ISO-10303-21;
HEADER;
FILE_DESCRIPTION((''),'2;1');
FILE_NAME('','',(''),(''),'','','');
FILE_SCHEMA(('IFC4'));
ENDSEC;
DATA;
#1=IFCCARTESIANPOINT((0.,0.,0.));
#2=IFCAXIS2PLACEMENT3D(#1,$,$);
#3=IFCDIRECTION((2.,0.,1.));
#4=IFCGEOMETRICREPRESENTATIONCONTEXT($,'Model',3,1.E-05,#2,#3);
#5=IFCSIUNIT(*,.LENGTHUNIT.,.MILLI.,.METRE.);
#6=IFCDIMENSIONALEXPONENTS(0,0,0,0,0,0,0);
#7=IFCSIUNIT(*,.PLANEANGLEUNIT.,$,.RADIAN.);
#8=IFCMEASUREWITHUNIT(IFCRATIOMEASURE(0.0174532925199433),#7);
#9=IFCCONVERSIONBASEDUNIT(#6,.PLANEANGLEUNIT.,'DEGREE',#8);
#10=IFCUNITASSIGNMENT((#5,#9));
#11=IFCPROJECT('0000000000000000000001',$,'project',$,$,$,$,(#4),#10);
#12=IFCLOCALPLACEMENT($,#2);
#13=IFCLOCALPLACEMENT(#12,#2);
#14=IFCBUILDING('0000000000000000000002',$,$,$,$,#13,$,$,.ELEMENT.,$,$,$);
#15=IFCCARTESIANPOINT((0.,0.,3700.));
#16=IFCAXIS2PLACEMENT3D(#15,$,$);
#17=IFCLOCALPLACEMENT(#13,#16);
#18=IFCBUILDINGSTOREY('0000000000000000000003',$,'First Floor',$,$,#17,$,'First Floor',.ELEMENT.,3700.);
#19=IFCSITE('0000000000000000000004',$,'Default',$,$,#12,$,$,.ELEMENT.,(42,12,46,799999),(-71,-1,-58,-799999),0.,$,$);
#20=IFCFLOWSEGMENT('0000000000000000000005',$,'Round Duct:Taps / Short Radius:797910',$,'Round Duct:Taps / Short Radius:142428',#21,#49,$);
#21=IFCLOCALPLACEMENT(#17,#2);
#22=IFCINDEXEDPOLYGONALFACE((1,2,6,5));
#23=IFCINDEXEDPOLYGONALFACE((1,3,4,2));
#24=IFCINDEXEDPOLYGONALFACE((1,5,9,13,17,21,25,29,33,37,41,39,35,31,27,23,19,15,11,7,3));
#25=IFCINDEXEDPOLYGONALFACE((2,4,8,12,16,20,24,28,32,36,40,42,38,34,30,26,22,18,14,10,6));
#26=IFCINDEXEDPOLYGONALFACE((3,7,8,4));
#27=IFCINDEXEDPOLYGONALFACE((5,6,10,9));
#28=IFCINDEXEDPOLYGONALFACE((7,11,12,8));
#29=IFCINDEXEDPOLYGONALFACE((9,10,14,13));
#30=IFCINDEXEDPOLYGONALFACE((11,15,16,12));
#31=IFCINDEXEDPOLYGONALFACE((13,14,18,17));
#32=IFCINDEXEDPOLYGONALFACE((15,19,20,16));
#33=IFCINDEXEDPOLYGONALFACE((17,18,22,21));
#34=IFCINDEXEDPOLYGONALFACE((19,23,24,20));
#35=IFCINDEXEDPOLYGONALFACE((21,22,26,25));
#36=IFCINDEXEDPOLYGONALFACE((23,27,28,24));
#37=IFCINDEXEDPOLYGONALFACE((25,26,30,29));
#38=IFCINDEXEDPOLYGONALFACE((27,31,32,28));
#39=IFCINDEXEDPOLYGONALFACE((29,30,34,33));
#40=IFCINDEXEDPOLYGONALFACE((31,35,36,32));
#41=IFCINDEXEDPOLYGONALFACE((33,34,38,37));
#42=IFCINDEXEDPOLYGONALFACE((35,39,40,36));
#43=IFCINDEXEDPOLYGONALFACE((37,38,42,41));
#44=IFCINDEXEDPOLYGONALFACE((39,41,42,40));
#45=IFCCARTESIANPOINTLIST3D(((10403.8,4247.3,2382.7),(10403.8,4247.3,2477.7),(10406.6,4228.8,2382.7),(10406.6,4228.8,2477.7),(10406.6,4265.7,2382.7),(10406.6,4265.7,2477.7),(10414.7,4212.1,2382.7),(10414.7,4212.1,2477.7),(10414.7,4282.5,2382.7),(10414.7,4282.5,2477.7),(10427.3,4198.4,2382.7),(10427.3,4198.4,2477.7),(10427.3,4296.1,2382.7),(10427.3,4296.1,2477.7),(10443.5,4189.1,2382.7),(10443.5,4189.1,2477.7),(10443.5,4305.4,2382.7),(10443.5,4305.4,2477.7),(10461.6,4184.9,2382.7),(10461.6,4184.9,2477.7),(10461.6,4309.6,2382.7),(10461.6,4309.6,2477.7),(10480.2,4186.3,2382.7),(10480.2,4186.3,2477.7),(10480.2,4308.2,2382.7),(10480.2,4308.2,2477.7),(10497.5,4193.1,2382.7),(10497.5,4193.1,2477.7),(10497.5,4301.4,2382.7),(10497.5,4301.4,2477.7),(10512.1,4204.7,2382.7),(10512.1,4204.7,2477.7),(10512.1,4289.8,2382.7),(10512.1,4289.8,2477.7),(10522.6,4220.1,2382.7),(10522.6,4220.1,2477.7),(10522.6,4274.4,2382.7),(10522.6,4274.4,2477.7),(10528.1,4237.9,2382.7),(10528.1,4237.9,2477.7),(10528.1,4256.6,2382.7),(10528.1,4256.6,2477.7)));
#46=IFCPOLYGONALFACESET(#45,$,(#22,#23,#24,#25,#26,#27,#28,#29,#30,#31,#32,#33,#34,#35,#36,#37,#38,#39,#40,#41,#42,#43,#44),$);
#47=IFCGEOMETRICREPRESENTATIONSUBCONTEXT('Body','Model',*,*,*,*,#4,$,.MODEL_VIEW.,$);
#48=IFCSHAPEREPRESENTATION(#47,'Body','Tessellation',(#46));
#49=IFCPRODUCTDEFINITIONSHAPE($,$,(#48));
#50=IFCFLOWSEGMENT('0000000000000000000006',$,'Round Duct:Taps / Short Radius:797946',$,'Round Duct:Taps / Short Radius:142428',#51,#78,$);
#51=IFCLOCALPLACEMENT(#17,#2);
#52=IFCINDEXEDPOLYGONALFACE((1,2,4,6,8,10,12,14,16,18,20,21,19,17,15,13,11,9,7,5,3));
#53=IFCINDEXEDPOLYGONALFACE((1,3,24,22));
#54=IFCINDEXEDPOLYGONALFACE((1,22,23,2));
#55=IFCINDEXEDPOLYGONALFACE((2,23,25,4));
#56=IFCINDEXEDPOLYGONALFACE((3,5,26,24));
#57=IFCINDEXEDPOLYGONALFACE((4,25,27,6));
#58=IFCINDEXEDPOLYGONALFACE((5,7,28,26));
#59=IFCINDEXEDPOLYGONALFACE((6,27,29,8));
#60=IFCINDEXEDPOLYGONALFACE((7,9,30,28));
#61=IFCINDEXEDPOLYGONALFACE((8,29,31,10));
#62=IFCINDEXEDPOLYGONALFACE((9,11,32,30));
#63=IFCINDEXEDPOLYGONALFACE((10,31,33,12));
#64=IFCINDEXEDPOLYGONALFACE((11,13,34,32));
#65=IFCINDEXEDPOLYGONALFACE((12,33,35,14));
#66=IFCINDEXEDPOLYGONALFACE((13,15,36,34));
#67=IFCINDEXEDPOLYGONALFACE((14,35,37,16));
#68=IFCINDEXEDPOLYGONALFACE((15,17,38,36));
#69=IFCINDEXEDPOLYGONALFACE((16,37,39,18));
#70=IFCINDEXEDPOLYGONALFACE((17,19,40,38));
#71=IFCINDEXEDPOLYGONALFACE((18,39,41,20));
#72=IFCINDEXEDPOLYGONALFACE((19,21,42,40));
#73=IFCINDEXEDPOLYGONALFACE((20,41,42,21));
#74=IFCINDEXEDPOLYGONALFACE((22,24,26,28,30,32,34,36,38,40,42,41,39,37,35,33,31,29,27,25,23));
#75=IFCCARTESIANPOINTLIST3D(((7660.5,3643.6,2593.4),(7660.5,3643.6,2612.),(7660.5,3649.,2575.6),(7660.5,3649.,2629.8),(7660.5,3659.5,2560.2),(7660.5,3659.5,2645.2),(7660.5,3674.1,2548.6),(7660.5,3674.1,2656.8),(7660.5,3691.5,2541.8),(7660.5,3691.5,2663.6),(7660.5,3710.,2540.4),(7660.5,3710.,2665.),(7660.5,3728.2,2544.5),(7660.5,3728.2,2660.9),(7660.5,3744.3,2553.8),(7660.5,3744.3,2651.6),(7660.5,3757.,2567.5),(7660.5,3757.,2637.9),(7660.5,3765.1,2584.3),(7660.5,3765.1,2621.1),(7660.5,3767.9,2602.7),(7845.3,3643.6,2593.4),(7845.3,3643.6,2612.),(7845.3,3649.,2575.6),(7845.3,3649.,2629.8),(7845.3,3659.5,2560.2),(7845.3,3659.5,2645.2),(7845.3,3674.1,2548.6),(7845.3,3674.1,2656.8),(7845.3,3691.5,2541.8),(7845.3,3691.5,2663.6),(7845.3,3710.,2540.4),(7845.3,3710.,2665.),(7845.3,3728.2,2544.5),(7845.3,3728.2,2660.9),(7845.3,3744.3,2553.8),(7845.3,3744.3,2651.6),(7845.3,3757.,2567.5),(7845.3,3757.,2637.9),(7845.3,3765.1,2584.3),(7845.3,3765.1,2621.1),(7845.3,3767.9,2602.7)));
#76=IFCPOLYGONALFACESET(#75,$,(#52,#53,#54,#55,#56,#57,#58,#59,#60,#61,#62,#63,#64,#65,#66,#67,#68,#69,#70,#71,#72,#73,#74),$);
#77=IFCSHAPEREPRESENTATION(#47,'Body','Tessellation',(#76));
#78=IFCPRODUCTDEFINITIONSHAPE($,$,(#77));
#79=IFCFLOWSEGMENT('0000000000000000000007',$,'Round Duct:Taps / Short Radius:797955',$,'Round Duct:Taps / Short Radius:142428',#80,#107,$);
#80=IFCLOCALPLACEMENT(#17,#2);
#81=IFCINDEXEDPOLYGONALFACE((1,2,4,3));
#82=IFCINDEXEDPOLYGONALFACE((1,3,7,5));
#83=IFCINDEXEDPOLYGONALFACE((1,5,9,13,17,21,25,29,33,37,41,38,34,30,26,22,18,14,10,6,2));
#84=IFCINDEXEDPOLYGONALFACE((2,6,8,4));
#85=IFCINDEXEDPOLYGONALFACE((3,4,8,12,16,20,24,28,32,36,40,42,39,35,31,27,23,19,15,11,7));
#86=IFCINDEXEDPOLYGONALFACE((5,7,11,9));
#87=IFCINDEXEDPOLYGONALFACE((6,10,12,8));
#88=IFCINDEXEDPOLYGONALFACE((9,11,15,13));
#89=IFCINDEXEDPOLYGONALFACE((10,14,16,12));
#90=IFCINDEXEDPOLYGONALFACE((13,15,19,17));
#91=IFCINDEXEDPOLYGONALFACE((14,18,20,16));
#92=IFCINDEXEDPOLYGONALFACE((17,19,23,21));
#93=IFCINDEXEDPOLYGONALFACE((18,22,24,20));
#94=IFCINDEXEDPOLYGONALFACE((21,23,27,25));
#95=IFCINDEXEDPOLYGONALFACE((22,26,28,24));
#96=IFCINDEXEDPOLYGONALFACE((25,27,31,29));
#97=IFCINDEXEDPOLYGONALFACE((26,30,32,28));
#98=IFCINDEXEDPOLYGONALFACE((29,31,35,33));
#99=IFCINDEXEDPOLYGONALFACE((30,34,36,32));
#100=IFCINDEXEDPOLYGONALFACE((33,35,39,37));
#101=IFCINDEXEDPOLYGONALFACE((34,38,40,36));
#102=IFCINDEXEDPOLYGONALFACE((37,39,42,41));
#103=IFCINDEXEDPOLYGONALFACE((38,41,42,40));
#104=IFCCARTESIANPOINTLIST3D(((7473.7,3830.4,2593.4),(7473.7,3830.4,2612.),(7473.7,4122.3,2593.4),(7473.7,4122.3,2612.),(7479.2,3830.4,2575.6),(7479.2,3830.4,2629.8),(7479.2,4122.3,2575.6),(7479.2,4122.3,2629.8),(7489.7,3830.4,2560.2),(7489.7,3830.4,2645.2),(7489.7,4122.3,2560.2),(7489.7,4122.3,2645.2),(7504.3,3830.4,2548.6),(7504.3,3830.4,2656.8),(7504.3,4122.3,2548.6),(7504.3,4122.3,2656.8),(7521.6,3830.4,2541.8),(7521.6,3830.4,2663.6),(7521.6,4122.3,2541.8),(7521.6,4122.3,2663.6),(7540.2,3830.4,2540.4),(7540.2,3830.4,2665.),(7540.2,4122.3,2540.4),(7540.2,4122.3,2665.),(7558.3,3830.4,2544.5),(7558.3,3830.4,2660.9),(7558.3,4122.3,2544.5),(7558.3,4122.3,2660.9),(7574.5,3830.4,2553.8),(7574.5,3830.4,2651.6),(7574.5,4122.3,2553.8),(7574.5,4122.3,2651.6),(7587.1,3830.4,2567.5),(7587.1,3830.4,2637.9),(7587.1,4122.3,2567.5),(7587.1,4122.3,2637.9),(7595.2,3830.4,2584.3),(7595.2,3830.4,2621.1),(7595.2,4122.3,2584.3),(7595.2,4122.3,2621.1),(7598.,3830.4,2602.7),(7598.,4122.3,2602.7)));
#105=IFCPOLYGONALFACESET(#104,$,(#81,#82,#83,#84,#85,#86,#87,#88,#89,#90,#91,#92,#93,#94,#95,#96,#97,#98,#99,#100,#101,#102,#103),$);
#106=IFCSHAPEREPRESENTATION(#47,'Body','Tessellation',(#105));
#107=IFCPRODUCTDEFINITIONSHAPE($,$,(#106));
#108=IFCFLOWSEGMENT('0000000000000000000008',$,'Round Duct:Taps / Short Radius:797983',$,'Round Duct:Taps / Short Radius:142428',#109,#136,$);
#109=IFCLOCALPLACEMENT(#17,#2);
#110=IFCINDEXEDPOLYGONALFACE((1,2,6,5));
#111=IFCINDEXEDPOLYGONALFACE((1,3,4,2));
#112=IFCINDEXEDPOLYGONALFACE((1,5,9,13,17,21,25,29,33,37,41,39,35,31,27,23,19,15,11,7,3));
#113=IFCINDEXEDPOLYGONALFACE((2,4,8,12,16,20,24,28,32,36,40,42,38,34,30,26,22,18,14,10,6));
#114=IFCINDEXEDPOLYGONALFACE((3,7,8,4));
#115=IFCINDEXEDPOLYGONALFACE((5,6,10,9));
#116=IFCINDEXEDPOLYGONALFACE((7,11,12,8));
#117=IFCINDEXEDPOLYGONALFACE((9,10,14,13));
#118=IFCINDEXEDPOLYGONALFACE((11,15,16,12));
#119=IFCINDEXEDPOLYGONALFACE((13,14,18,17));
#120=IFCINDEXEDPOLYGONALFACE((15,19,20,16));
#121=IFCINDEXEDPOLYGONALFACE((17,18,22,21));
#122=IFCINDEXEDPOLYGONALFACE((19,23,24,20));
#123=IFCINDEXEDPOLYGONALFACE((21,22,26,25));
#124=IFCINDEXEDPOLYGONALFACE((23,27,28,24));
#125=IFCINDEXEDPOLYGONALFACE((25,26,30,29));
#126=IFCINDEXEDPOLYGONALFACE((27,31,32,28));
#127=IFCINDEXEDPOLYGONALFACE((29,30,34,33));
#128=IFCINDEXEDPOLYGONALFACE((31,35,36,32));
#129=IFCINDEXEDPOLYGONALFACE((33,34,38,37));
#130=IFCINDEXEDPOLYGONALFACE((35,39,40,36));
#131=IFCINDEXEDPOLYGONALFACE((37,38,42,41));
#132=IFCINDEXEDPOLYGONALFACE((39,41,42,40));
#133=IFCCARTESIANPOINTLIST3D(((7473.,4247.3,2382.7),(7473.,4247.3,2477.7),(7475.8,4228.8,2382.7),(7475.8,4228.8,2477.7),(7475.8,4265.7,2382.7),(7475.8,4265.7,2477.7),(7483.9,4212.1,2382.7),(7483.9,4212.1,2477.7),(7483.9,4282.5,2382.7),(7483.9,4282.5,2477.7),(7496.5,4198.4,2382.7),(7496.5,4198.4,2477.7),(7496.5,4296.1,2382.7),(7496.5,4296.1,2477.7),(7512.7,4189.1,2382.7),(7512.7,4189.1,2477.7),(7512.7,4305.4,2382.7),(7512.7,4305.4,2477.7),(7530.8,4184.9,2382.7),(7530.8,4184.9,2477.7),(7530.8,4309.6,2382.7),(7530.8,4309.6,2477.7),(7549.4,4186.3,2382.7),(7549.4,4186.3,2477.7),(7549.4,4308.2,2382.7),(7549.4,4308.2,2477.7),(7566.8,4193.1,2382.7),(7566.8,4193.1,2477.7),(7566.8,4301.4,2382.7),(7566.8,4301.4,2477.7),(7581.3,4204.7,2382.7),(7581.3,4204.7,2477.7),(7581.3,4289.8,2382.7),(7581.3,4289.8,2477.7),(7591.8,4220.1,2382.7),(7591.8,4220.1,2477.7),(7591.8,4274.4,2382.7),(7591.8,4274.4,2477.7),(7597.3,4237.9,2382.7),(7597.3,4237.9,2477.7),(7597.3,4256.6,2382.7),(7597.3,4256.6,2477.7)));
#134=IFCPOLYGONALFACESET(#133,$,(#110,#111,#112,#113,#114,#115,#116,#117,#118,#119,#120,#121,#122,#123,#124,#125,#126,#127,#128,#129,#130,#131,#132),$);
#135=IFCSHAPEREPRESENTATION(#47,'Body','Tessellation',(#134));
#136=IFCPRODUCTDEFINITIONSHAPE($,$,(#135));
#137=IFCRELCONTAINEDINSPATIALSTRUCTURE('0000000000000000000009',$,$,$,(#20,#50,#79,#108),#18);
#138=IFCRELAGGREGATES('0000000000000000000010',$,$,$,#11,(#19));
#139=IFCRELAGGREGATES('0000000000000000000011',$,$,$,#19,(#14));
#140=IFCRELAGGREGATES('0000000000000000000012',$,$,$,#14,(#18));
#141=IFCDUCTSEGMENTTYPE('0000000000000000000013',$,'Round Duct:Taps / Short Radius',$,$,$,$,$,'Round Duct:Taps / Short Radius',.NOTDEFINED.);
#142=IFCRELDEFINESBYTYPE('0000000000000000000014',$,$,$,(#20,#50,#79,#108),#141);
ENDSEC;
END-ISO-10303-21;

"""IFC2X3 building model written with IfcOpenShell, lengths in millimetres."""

from ifc_helpers import new_model, entity, si_unit, converted_unit, direction, frame, frame_2d, origin, origin_2d_with_axis, place, context, subcontext, project, spatial, circle, extrude, type_object, element, save


model = new_model("IFC2X3")

# Units and contexts
model_context = context("Model", 3, precision=1e-05, world=origin(), true_north=direction((2.0, 0.0, 1.0)))
body_context = subcontext(model_context, "Body", "Model", "MODEL_VIEW")
ifc_project = project(units=[si_unit("LENGTHUNIT", "METRE", prefix="MILLI"), converted_unit("PLANEANGLEUNIT", "DEGREE", entity("IfcRatioMeasure", 0.0174532925199433), si_unit("PLANEANGLEUNIT", "RADIAN"), dimensions=[0, 0, 0, 0, 0, 0, 0])], contexts=[model_context])

# Site, building, storey
site_placement = place(None, origin())
site = spatial("IfcSite", under=ifc_project, at=site_placement, Name="Default", CompositionType="ELEMENT", RefLatitude=(42, 12, 46, 799999), RefLongitude=(-71, -1, -58, -799999), RefElevation=0.0)
building_placement = place(site_placement, origin())
building = spatial("IfcBuilding", under=site, at=building_placement, CompositionType="ELEMENT")
storey_placement = place(building_placement, frame((0.0, 0.0, 3700.0)))
storey = spatial("IfcBuildingStorey", under=building, at=storey_placement, Name="First Floor", LongName="First Floor", CompositionType="ELEMENT", Elevation=3700.0)

# Flow segments
duct_segment_type = type_object("IfcDuctSegmentType", Name="Round Duct:Taps / Short Radius", ElementType="Round Duct:Taps / Short Radius", PredefinedType="NOTDEFINED")
flow_segment_1_placement = place(storey_placement, origin())
element("IfcFlowSegment", 1, at=flow_segment_1_placement, inside=storey, type_object=duct_segment_type, Name="Round Duct:Taps / Short Radius:797910", ObjectType="Round Duct:Taps / Short Radius:142428", context=body_context, shape_type="SweptSolid", body=[
    extrude(circle(Radius=62.5, at=frame_2d((0.0, 0.0), x_axis=(1.0, 0.0))), frame((10466.3, 4247.3, 2382.7), z_axis=(0.0, 0.0, 1.0), x_axis=(-1.0, 0.0, 0.0)), (0.0, 0.0, 1.0), 95.0),
])
flow_segment_2_placement = place(storey_placement, origin())
element("IfcFlowSegment", 2, at=flow_segment_2_placement, inside=storey, type_object=duct_segment_type, Name="Round Duct:Taps / Short Radius:797946", ObjectType="Round Duct:Taps / Short Radius:142428", context=body_context, shape_type="SweptSolid", body=[
    extrude(circle(Radius=62.5, at=frame_2d((0.0, 0.0), x_axis=(1.0, 0.0))), frame((7660.5, 3705.4, 2602.7), z_axis=(1.0, 0.0, 0.0), x_axis=(0.0, 1.0, 0.0)), (0.0, 0.0, 1.0), 184.8),
])
flow_segment_3_placement = place(storey_placement, origin())
element("IfcFlowSegment", 3, at=flow_segment_3_placement, inside=storey, type_object=duct_segment_type, Name="Round Duct:Taps / Short Radius:797955", ObjectType="Round Duct:Taps / Short Radius:142428", context=body_context, shape_type="SweptSolid", body=[
    extrude(circle(Radius=62.5, at=origin_2d_with_axis()), frame((7535.5, 3830.4, 2602.7), z_axis=(0.0, 1.0, 0.0), x_axis=(1.0, 0.0, 0.0)), (0.0, 0.0, 1.0), 291.9),
])
flow_segment_4_placement = place(storey_placement, origin())
element("IfcFlowSegment", 4, at=flow_segment_4_placement, inside=storey, type_object=duct_segment_type, Name="Round Duct:Taps / Short Radius:797983", ObjectType="Round Duct:Taps / Short Radius:142428", context=body_context, shape_type="SweptSolid", body=[
    extrude(circle(Radius=62.5, at=frame_2d((0.0, 0.0), x_axis=(1.0, 0.0))), frame((7535.5, 4247.3, 2382.7), z_axis=(0.0, 0.0, 1.0), x_axis=(-1.0, 0.0, 0.0)), (0.0, 0.0, 1.0), 95.0),
])

save(model, "model.ifc")
